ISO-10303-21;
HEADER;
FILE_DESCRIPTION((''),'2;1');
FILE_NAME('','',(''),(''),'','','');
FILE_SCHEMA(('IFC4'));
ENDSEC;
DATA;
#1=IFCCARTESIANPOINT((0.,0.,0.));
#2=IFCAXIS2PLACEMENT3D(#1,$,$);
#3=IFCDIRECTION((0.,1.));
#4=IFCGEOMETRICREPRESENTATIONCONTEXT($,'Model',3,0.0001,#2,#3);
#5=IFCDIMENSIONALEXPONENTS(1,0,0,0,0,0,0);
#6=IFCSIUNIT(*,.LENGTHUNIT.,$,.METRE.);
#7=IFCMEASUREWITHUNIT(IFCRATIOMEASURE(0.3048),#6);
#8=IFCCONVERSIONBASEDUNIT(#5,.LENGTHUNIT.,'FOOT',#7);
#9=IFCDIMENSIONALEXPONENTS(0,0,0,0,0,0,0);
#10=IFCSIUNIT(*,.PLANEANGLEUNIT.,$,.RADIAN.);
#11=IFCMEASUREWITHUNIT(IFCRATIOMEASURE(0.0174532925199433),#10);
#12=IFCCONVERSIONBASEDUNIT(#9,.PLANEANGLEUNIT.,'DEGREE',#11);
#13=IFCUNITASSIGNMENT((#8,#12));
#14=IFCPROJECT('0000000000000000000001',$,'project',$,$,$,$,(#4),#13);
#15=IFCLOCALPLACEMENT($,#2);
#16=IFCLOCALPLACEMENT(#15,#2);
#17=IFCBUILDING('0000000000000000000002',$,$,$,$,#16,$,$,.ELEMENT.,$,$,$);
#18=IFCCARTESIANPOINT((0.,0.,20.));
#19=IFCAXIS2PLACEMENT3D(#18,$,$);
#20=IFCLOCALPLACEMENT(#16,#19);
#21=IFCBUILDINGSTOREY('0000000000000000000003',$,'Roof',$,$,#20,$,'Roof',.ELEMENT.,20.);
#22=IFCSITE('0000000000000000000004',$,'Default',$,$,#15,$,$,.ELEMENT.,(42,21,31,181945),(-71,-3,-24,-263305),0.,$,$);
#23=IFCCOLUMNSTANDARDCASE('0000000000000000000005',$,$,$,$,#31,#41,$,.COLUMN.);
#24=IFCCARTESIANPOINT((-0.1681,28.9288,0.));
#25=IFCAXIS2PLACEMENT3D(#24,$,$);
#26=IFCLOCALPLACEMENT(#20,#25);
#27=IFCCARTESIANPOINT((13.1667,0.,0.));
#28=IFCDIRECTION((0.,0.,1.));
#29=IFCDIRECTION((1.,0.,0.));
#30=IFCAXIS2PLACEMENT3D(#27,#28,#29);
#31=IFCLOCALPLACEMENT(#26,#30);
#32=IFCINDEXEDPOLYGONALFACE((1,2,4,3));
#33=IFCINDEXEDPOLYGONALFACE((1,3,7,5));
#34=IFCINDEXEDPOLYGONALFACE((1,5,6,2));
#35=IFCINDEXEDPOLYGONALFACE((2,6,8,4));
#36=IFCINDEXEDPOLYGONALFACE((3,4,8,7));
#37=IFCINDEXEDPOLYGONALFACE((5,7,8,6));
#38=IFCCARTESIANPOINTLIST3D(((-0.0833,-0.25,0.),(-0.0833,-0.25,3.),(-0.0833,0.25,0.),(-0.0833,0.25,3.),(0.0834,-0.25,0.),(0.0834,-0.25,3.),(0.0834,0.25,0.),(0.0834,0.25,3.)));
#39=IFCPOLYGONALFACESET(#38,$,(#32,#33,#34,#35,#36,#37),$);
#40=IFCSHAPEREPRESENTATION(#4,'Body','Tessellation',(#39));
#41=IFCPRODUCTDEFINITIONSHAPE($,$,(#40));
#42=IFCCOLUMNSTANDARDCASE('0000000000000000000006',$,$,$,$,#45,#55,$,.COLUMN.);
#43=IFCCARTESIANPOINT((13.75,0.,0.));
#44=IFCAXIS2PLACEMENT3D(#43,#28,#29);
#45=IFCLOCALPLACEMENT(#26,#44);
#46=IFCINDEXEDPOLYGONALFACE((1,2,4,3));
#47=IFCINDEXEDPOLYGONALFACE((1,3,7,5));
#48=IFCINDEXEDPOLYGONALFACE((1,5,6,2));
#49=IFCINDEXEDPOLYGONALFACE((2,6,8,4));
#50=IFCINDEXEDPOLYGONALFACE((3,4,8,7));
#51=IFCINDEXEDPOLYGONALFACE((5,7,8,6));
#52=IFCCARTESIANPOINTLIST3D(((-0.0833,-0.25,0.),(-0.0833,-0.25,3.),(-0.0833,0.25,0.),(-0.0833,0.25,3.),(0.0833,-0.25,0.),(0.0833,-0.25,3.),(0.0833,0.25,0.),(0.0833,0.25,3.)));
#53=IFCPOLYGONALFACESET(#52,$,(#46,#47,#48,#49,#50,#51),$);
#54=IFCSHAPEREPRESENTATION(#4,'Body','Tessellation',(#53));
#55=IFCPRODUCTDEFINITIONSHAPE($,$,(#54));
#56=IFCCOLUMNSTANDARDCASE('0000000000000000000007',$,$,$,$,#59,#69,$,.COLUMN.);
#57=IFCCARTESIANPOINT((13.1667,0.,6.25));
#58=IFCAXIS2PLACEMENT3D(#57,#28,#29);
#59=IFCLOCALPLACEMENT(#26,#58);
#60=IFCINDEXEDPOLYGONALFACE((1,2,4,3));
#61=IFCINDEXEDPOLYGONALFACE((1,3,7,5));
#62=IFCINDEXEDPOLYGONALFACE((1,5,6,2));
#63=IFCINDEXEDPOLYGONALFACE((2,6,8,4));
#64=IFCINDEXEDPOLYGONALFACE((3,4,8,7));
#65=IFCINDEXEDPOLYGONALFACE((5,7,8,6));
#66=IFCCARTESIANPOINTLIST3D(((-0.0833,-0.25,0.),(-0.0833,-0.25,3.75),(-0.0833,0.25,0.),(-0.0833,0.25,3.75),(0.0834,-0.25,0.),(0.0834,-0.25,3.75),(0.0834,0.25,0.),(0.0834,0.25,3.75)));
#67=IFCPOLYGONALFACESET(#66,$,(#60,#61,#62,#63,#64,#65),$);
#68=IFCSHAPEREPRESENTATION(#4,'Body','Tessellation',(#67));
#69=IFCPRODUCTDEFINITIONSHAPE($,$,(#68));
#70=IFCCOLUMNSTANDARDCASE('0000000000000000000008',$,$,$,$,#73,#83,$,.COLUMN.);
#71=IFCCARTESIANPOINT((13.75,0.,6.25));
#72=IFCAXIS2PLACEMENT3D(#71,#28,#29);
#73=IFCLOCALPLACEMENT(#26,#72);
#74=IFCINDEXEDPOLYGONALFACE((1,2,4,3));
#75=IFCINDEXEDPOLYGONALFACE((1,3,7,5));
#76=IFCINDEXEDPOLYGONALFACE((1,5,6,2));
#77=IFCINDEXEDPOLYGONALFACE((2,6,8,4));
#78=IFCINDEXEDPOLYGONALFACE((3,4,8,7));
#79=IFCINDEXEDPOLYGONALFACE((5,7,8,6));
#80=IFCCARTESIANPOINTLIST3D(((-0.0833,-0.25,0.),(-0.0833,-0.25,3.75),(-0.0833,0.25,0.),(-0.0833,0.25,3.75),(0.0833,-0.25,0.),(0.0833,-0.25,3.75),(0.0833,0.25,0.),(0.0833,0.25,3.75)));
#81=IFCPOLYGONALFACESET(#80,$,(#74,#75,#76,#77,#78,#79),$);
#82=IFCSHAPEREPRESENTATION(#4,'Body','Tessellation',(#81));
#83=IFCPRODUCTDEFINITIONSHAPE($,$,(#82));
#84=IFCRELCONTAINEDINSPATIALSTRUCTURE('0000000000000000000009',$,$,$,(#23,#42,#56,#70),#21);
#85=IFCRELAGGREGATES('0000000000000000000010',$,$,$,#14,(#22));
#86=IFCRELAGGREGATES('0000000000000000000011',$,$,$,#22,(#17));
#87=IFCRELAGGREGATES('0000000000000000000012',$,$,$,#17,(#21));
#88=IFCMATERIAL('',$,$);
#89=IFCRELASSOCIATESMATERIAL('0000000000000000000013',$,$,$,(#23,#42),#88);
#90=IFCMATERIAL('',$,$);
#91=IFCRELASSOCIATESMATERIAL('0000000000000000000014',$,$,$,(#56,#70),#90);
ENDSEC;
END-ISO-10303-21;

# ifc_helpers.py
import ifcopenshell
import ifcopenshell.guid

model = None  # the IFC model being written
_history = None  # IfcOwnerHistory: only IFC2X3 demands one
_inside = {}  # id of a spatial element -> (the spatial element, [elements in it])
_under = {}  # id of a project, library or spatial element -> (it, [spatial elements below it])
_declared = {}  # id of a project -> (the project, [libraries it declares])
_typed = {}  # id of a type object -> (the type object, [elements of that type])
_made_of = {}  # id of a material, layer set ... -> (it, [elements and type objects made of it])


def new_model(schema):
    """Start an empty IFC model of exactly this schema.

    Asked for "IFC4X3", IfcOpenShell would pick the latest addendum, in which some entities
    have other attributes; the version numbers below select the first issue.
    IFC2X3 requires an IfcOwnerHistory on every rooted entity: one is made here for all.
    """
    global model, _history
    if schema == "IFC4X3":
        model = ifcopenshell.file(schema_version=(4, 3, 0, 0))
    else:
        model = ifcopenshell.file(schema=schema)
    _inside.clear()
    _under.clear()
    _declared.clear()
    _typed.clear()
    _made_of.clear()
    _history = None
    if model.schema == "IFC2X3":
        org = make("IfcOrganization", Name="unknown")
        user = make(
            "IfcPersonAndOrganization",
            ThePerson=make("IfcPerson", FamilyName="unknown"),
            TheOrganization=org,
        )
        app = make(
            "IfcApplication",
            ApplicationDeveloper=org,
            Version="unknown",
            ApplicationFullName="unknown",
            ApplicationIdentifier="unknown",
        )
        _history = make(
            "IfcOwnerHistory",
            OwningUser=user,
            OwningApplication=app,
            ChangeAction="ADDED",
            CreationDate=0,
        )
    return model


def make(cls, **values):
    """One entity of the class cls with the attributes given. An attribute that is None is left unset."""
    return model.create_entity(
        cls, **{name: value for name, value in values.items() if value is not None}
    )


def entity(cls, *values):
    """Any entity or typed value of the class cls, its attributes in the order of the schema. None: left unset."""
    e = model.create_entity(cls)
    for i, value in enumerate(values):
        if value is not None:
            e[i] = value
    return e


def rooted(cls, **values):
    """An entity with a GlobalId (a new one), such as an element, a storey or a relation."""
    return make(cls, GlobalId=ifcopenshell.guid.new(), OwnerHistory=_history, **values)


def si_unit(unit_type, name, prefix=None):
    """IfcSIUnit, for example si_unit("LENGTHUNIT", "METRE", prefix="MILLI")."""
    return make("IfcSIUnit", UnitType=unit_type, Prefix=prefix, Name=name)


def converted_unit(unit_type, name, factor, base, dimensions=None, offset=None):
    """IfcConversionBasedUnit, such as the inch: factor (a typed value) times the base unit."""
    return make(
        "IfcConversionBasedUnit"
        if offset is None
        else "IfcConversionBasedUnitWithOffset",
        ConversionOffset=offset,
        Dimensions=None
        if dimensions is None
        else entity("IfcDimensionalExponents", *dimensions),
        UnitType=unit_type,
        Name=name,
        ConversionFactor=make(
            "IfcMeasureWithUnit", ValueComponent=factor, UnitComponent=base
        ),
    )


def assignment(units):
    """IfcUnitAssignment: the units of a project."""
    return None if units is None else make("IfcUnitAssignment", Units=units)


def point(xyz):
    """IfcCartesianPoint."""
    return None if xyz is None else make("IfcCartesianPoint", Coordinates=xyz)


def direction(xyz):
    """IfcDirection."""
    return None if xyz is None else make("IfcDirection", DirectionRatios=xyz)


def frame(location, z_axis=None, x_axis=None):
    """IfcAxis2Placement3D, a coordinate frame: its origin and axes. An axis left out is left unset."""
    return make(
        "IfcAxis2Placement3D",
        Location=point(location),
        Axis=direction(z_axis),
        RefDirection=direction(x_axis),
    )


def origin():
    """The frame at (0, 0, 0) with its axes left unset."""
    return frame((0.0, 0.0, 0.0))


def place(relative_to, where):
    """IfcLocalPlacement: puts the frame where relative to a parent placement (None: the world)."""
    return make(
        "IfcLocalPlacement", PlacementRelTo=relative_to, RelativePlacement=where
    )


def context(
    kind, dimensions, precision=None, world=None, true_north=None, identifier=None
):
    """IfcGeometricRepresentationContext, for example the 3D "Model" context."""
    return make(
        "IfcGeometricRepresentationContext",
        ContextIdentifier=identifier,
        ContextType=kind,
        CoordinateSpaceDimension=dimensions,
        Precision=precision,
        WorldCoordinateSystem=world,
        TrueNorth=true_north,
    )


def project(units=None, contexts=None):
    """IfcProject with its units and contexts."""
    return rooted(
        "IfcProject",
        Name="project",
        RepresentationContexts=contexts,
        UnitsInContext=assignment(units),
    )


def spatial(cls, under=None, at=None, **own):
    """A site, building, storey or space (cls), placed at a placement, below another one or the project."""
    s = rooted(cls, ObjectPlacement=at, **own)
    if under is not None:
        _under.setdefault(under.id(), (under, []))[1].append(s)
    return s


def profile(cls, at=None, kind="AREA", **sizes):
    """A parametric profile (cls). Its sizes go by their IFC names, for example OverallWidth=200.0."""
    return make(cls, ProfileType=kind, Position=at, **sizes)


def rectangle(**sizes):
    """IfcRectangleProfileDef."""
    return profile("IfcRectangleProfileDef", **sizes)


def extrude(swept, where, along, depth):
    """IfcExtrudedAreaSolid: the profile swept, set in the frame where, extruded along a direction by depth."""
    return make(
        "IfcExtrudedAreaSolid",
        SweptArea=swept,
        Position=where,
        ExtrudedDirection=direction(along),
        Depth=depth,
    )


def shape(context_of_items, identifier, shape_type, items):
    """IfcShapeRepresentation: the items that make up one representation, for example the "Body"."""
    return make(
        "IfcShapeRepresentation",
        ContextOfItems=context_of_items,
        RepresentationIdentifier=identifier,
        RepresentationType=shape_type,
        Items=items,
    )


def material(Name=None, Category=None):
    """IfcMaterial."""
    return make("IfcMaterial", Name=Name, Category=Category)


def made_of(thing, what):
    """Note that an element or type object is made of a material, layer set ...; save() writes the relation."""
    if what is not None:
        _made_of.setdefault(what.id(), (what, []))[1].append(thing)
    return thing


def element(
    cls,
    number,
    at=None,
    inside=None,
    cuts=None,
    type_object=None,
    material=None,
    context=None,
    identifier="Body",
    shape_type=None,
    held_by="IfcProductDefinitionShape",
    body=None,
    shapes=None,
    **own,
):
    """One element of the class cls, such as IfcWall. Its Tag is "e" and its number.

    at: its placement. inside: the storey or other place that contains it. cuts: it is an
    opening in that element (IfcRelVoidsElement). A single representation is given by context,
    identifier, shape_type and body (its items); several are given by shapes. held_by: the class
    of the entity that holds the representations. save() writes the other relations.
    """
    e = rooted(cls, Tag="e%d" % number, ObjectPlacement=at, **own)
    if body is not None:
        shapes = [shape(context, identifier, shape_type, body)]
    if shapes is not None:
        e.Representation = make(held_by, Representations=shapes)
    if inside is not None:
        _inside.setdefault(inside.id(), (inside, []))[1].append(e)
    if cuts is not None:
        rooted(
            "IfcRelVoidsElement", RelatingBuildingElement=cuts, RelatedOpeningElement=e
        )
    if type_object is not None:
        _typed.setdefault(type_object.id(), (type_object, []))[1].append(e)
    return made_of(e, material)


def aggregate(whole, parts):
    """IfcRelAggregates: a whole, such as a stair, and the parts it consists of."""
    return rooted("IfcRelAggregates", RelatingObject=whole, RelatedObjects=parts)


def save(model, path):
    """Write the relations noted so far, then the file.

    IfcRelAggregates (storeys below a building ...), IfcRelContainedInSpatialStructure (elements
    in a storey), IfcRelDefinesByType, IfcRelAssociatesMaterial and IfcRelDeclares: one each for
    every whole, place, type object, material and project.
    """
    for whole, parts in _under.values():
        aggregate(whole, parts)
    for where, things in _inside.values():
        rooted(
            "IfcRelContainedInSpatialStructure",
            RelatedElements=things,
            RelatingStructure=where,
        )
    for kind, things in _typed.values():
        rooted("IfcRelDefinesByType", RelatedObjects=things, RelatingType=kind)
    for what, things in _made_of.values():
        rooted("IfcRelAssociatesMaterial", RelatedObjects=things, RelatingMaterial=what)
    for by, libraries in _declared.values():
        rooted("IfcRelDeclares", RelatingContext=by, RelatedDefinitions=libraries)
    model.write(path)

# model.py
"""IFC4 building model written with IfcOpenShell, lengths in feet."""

from ifc_helpers import new_model, entity, si_unit, converted_unit, direction, frame, origin, place, context, project, spatial, rectangle, extrude, material, element, save


model = new_model("IFC4")

# Units and contexts
model_context = context("Model", 3, precision=0.0001, world=origin(), true_north=direction((0.0, 1.0)))
ifc_project = project(units=[converted_unit("LENGTHUNIT", "FOOT", entity("IfcRatioMeasure", 0.3048), si_unit("LENGTHUNIT", "METRE"), dimensions=[1, 0, 0, 0, 0, 0, 0]), converted_unit("PLANEANGLEUNIT", "DEGREE", entity("IfcRatioMeasure", 0.0174532925199433), si_unit("PLANEANGLEUNIT", "RADIAN"), dimensions=[0, 0, 0, 0, 0, 0, 0])], contexts=[model_context])

# Site, building, storey
site_placement = place(None, origin())
site = spatial("IfcSite", under=ifc_project, at=site_placement, Name="Default", CompositionType="ELEMENT", RefLatitude=(42, 21, 31, 181945), RefLongitude=(-71, -3, -24, -263305), RefElevation=0.0)
building_placement = place(site_placement, origin())
building = spatial("IfcBuilding", under=site, at=building_placement, CompositionType="ELEMENT")
storey_placement = place(building_placement, frame((0.0, 0.0, 20.0)))
storey = spatial("IfcBuildingStorey", under=building, at=storey_placement, Name="Roof", LongName="Roof", CompositionType="ELEMENT", Elevation=20.0)

# Columns
ifc_material_1 = material(Name="")
placement = place(storey_placement, frame((-0.1681, 28.9288, 0.0)))
for number, where, z_axis, x_axis in (
    (1, (13.1667, 0.0, 0.0), (0.0, 0.0, 1.0), (1.0, 0.0, 0.0)),
    (2, (13.75, 0.0, 0.0), (0.0, 0.0, 1.0), (1.0, 0.0, 0.0)),
):
    element("IfcColumnStandardCase", number, at=place(placement, frame(where, z_axis=z_axis, x_axis=x_axis)), inside=storey, material=ifc_material_1, PredefinedType="COLUMN", context=model_context, shape_type="SweptSolid", body=[
        extrude(rectangle(XDim=0.1667, YDim=0.5), origin(), (0.0, 0.0, 1.0), 3.0),
    ])
ifc_material_2 = material(Name="")
for number, where, z_axis, x_axis in (
    (3, (13.1667, 0.0, 6.25), (0.0, 0.0, 1.0), (1.0, 0.0, 0.0)),
    (4, (13.75, 0.0, 6.25), (0.0, 0.0, 1.0), (1.0, 0.0, 0.0)),
):
    element("IfcColumnStandardCase", number, at=place(placement, frame(where, z_axis=z_axis, x_axis=x_axis)), inside=storey, material=ifc_material_2, PredefinedType="COLUMN", context=model_context, shape_type="SweptSolid", body=[
        extrude(rectangle(XDim=0.1667, YDim=0.5), origin(), (0.0, 0.0, 1.0), 3.75),
    ])

save(model, "model.ifc")
